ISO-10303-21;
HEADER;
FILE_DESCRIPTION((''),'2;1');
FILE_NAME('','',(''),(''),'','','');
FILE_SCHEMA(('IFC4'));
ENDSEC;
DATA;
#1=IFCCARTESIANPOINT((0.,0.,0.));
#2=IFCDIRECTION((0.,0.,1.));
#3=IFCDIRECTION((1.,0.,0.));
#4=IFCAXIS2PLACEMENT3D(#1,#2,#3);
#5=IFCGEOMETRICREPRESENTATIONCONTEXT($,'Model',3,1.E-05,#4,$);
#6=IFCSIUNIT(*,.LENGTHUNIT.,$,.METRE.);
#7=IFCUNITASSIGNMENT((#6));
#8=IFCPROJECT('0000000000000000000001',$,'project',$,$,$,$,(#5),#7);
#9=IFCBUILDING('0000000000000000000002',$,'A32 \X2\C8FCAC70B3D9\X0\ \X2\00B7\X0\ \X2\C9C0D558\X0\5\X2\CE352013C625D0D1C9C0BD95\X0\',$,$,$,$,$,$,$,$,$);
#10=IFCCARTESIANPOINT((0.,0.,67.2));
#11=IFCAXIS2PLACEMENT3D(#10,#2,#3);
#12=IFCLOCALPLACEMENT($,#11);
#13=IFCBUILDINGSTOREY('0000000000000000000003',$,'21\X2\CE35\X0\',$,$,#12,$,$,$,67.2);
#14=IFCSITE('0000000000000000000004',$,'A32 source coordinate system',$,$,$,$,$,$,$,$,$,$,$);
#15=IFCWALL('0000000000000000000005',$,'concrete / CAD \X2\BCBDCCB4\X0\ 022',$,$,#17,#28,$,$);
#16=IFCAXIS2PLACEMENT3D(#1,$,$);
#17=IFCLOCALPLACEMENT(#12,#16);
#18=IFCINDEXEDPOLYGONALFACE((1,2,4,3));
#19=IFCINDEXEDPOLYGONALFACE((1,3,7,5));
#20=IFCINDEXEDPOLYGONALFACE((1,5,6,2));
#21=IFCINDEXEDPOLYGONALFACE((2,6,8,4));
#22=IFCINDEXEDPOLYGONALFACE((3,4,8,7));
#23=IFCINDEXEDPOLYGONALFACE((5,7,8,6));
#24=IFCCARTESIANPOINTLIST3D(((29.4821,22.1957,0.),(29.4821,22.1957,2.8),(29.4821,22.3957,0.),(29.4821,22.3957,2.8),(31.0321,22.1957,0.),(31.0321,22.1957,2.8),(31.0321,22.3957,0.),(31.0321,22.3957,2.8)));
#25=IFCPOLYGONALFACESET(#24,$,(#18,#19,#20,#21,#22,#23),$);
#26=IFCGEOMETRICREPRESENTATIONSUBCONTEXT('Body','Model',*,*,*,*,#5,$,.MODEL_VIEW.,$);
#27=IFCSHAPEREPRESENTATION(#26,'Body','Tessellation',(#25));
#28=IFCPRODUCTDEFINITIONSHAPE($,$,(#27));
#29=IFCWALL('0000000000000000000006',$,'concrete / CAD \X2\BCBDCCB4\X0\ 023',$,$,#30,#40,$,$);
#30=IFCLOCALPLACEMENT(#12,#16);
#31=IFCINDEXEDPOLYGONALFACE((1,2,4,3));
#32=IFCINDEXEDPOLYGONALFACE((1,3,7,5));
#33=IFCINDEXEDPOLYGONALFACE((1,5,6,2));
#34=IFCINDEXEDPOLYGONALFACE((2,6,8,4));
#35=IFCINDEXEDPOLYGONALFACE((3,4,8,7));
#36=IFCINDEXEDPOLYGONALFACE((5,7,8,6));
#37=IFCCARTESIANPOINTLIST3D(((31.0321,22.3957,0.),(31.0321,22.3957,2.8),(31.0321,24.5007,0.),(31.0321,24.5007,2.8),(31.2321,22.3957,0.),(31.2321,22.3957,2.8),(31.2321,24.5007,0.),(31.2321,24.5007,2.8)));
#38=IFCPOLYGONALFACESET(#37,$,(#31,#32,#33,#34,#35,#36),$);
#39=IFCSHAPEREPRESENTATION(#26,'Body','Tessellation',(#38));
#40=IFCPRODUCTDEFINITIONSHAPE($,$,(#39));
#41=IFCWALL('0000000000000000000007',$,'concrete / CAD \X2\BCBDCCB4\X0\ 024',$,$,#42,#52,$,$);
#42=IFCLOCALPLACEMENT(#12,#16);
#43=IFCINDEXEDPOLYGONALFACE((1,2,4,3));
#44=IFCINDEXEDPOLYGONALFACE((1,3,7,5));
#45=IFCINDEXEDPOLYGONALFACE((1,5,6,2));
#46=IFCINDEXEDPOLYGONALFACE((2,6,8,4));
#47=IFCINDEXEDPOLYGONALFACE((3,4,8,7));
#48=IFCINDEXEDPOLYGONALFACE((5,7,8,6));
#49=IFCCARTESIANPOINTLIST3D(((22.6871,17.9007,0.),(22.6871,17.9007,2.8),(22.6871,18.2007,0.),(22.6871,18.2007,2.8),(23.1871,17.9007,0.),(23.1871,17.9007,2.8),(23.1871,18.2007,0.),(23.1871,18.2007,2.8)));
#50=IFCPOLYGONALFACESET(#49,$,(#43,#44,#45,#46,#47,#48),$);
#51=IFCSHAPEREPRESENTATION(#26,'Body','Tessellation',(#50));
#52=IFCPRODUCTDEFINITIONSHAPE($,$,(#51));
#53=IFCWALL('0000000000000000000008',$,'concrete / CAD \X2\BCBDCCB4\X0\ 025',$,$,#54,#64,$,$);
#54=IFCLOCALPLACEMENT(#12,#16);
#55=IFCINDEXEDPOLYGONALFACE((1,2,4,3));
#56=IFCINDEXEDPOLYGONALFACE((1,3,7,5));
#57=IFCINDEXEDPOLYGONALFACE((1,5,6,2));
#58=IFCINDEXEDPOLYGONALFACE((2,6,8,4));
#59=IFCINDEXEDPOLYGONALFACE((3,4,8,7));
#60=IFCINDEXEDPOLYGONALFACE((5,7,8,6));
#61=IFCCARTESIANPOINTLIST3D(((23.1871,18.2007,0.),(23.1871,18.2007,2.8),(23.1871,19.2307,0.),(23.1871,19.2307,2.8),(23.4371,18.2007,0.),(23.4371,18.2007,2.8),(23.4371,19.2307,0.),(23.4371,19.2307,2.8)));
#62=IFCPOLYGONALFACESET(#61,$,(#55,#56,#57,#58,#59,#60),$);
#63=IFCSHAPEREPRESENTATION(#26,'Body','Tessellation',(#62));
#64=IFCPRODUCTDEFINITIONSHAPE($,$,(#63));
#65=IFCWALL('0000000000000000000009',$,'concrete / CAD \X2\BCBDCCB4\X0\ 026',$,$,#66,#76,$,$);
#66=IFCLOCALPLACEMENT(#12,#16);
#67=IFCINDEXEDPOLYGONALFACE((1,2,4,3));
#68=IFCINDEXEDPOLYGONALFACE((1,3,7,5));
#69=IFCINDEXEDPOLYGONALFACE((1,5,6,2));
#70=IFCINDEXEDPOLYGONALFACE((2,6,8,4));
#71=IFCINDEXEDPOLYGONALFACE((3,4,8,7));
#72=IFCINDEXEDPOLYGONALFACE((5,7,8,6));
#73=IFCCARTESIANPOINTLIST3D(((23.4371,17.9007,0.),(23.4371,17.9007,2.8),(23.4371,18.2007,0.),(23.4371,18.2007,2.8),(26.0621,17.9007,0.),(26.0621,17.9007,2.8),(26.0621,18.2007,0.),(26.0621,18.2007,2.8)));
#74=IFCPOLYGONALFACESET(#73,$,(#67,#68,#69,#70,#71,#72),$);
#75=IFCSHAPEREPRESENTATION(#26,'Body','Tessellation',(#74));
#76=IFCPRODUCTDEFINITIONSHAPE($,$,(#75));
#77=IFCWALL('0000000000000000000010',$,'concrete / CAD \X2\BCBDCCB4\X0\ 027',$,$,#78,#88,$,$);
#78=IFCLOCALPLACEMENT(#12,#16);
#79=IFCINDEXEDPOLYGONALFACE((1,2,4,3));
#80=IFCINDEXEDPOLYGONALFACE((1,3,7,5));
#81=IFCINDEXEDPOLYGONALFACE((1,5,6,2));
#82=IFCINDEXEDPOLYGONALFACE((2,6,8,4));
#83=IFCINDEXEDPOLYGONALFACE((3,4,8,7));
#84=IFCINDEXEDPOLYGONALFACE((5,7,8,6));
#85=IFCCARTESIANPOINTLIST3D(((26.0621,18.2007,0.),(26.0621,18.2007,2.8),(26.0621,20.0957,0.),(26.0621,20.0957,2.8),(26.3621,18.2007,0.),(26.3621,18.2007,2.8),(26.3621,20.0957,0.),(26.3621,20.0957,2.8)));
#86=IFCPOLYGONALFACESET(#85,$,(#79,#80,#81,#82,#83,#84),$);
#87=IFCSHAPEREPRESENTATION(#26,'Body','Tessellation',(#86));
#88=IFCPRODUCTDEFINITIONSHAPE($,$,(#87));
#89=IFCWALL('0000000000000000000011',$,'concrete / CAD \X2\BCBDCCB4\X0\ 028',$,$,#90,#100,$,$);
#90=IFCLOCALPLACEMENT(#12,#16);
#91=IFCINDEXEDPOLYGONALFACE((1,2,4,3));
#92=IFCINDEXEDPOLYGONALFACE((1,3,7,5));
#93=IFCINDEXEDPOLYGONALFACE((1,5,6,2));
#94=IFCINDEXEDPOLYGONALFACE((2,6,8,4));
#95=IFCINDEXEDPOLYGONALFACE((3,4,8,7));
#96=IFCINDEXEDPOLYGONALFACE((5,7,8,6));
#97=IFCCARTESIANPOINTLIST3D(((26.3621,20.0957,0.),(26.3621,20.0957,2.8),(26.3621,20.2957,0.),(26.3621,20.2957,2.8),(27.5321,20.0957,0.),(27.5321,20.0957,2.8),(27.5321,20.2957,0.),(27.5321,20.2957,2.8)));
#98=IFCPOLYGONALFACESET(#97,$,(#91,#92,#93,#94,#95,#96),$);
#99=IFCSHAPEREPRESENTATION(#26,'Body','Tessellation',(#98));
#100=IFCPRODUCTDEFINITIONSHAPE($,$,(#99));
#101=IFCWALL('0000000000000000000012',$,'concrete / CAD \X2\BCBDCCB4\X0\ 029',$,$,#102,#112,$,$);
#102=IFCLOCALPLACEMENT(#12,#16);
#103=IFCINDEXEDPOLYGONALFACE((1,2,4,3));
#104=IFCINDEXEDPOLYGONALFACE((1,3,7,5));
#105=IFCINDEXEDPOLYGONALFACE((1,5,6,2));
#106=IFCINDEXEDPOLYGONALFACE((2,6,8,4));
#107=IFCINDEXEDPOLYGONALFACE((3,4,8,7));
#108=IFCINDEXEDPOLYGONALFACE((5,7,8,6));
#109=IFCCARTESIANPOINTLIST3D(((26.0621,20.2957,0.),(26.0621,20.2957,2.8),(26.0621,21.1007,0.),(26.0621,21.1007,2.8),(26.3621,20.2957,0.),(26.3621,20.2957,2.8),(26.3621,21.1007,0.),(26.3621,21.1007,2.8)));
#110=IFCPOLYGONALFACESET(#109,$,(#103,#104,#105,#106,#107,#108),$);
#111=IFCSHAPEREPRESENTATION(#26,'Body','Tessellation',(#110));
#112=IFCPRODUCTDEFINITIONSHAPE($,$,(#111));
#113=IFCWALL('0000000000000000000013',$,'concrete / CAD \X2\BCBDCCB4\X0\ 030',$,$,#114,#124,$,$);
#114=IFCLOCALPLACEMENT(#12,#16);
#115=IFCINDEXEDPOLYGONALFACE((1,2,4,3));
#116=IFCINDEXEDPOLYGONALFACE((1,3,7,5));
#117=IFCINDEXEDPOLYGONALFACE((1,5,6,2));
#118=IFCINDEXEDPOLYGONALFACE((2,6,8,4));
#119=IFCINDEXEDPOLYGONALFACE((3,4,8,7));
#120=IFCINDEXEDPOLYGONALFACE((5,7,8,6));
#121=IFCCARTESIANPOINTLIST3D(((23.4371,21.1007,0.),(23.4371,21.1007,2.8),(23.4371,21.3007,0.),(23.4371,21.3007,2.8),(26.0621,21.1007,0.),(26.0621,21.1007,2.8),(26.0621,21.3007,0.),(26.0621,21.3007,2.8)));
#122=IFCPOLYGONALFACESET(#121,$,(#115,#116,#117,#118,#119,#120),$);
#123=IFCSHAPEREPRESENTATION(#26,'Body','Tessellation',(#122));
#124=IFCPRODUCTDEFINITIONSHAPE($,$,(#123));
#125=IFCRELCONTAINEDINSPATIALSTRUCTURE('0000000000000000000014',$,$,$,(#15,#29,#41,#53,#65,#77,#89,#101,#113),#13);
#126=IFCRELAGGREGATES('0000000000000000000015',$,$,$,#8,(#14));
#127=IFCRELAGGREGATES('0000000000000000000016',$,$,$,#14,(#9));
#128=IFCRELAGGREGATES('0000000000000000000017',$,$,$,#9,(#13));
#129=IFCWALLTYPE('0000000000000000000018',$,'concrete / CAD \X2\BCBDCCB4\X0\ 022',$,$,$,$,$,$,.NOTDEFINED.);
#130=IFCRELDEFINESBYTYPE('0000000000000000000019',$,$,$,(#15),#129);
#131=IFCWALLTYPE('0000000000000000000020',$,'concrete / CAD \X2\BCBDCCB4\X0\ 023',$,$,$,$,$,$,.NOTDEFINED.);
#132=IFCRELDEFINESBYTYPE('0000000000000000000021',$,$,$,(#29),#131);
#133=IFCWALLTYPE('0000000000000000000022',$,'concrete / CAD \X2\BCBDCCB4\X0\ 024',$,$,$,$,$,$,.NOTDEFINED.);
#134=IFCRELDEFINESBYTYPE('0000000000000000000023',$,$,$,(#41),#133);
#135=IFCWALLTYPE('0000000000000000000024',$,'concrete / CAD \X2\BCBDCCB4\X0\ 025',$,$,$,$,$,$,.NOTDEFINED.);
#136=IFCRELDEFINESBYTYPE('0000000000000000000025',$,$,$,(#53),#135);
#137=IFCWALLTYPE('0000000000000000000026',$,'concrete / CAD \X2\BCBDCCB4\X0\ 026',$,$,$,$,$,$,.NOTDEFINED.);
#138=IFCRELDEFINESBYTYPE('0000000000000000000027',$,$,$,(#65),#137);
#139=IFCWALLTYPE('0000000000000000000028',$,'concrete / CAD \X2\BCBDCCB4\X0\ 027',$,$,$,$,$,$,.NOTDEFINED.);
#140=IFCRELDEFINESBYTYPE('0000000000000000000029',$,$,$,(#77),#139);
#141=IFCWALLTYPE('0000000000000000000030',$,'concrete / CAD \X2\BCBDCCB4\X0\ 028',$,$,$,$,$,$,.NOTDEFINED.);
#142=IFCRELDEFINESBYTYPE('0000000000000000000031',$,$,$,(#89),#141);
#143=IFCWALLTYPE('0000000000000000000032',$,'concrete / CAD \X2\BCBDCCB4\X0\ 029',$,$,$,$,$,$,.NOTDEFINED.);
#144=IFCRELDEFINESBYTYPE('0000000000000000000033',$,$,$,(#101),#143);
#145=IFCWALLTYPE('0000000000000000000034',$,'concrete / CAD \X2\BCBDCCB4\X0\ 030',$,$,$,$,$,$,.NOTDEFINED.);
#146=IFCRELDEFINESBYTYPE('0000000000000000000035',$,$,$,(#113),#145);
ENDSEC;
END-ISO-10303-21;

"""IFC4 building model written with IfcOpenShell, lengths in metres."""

from ifc_helpers import new_model, si_unit, frame, origin, origin_with_axes, place, context, subcontext, project, spatial, polyline, outline, extrude, source, transform, mapped, type_object, type_shapes, element, save


model = new_model("IFC4")

# Units and contexts
model_context = context("Model", 3, precision=1e-05, world=origin_with_axes())
body_context = subcontext(model_context, "Body", "Model", "MODEL_VIEW")
ifc_project = project(units=[si_unit("LENGTHUNIT", "METRE")], contexts=[model_context])

# Site, building, storey
site = spatial("IfcSite", under=ifc_project, Name="A32 source coordinate system")
building = spatial("IfcBuilding", under=site, Name="A32 주거동 · 지하5층–옥탑지붕")
storey_placement = place(None, frame((0.0, 0.0, 67.2), z_axis=(0.0, 0.0, 1.0), x_axis=(1.0, 0.0, 0.0)))
storey = spatial("IfcBuildingStorey", under=building, at=storey_placement, Name="21층", Elevation=67.2)

# Walls
wall_type_1 = type_object("IfcWallType", Name="concrete / CAD 벽체 022", PredefinedType="NOTDEFINED")
shared_shape_1 = source(origin(), body_context, "Body", "SweptSolid", [
    extrude(outline(polyline([(31.0321, 22.1957), (29.4821, 22.1957), (29.4821, 22.3957), (31.0321, 22.3957), (31.0321, 22.1957)])), origin(), (0.0, 0.0, 1.0), 2.8),
])
type_shapes(wall_type_1, [shared_shape_1])
wall_1_placement = place(storey_placement, origin_with_axes())
element("IfcWall", 1, at=wall_1_placement, inside=storey, type_object=wall_type_1, Name="concrete / CAD 벽체 022", context=body_context, shape_type="MappedRepresentation", body=[
    mapped(shared_shape_1, transform((0.0, 0.0, 0.0), scale=1.0)),
])
wall_type_2 = type_object("IfcWallType", Name="concrete / CAD 벽체 023", PredefinedType="NOTDEFINED")
shared_shape_2 = source(origin(), body_context, "Body", "SweptSolid", [
    extrude(outline(polyline([(31.2321, 24.5007), (31.2321, 22.3957), (31.0321, 22.3957), (31.0321, 24.5007), (31.2321, 24.5007)])), origin(), (0.0, 0.0, 1.0), 2.8),
])
type_shapes(wall_type_2, [shared_shape_2])
wall_2_placement = place(storey_placement, origin_with_axes())
element("IfcWall", 2, at=wall_2_placement, inside=storey, type_object=wall_type_2, Name="concrete / CAD 벽체 023", context=body_context, shape_type="MappedRepresentation", body=[
    mapped(shared_shape_2, transform((0.0, 0.0, 0.0), scale=1.0)),
])
wall_type_3 = type_object("IfcWallType", Name="concrete / CAD 벽체 024", PredefinedType="NOTDEFINED")
shared_shape_3 = source(origin(), body_context, "Body", "SweptSolid", [
    extrude(outline(polyline([(23.1871, 17.9007), (22.6871, 17.9007), (22.6871, 18.2007), (23.1871, 18.2007), (23.1871, 17.9007)])), origin(), (0.0, 0.0, 1.0), 2.8),
])
type_shapes(wall_type_3, [shared_shape_3])
wall_3_placement = place(storey_placement, origin_with_axes())
element("IfcWall", 3, at=wall_3_placement, inside=storey, type_object=wall_type_3, Name="concrete / CAD 벽체 024", context=body_context, shape_type="MappedRepresentation", body=[
    mapped(shared_shape_3, transform((0.0, 0.0, 0.0), scale=1.0)),
])
wall_type_4 = type_object("IfcWallType", Name="concrete / CAD 벽체 025", PredefinedType="NOTDEFINED")
shared_shape_4 = source(origin(), body_context, "Body", "SweptSolid", [
    extrude(outline(polyline([(23.4371, 19.2307), (23.4371, 18.2007), (23.1871, 18.2007), (23.1871, 19.2307), (23.4371, 19.2307)])), origin(), (0.0, 0.0, 1.0), 2.8),
])
type_shapes(wall_type_4, [shared_shape_4])
wall_4_placement = place(storey_placement, origin_with_axes())
element("IfcWall", 4, at=wall_4_placement, inside=storey, type_object=wall_type_4, Name="concrete / CAD 벽체 025", context=body_context, shape_type="MappedRepresentation", body=[
    mapped(shared_shape_4, transform((0.0, 0.0, 0.0), scale=1.0)),
])
wall_type_5 = type_object("IfcWallType", Name="concrete / CAD 벽체 026", PredefinedType="NOTDEFINED")
shared_shape_5 = source(origin(), body_context, "Body", "SweptSolid", [
    extrude(outline(polyline([(26.0621, 17.9007), (23.4371, 17.9007), (23.4371, 18.2007), (26.0621, 18.2007), (26.0621, 17.9007)])), origin(), (0.0, 0.0, 1.0), 2.8),
])
type_shapes(wall_type_5, [shared_shape_5])
wall_5_placement = place(storey_placement, origin_with_axes())
element("IfcWall", 5, at=wall_5_placement, inside=storey, type_object=wall_type_5, Name="concrete / CAD 벽체 026", context=body_context, shape_type="MappedRepresentation", body=[
    mapped(shared_shape_5, transform((0.0, 0.0, 0.0), scale=1.0)),
])
wall_type_6 = type_object("IfcWallType", Name="concrete / CAD 벽체 027", PredefinedType="NOTDEFINED")
shared_shape_6 = source(origin(), body_context, "Body", "SweptSolid", [
    extrude(outline(polyline([(26.3621, 20.0957), (26.3621, 18.2007), (26.0621, 18.2007), (26.0621, 20.0957), (26.3621, 20.0957)])), origin(), (0.0, 0.0, 1.0), 2.8),
])
type_shapes(wall_type_6, [shared_shape_6])
wall_6_placement = place(storey_placement, origin_with_axes())
element("IfcWall", 6, at=wall_6_placement, inside=storey, type_object=wall_type_6, Name="concrete / CAD 벽체 027", context=body_context, shape_type="MappedRepresentation", body=[
    mapped(shared_shape_6, transform((0.0, 0.0, 0.0), scale=1.0)),
])
wall_type_7 = type_object("IfcWallType", Name="concrete / CAD 벽체 028", PredefinedType="NOTDEFINED")
shared_shape_7 = source(origin(), body_context, "Body", "SweptSolid", [
    extrude(outline(polyline([(27.5321, 20.0957), (26.3621, 20.0957), (26.3621, 20.2957), (27.5321, 20.2957), (27.5321, 20.0957)])), origin(), (0.0, 0.0, 1.0), 2.8),
])
type_shapes(wall_type_7, [shared_shape_7])
wall_7_placement = place(storey_placement, origin_with_axes())
element("IfcWall", 7, at=wall_7_placement, inside=storey, type_object=wall_type_7, Name="concrete / CAD 벽체 028", context=body_context, shape_type="MappedRepresentation", body=[
    mapped(shared_shape_7, transform((0.0, 0.0, 0.0), scale=1.0)),
])
wall_type_8 = type_object("IfcWallType", Name="concrete / CAD 벽체 029", PredefinedType="NOTDEFINED")
shared_shape_8 = source(origin(), body_context, "Body", "SweptSolid", [
    extrude(outline(polyline([(26.3621, 21.1007), (26.3621, 20.2957), (26.0621, 20.2957), (26.0621, 21.1007), (26.3621, 21.1007)])), origin(), (0.0, 0.0, 1.0), 2.8),
])
type_shapes(wall_type_8, [shared_shape_8])
wall_8_placement = place(storey_placement, origin_with_axes())
element("IfcWall", 8, at=wall_8_placement, inside=storey, type_object=wall_type_8, Name="concrete / CAD 벽체 029", context=body_context, shape_type="MappedRepresentation", body=[
    mapped(shared_shape_8, transform((0.0, 0.0, 0.0), scale=1.0)),
])
wall_type_9 = type_object("IfcWallType", Name="concrete / CAD 벽체 030", PredefinedType="NOTDEFINED")
shared_shape_9 = source(origin(), body_context, "Body", "SweptSolid", [
    extrude(outline(polyline([(23.4371, 21.3007), (26.0621, 21.3007), (26.0621, 21.1007), (23.4371, 21.1007), (23.4371, 21.3007)])), origin(), (0.0, 0.0, 1.0), 2.8),
])
type_shapes(wall_type_9, [shared_shape_9])
wall_9_placement = place(storey_placement, origin_with_axes())
element("IfcWall", 9, at=wall_9_placement, inside=storey, type_object=wall_type_9, Name="concrete / CAD 벽체 030", context=body_context, shape_type="MappedRepresentation", body=[
    mapped(shared_shape_9, transform((0.0, 0.0, 0.0), scale=1.0)),
])

save(model, "model.ifc")
